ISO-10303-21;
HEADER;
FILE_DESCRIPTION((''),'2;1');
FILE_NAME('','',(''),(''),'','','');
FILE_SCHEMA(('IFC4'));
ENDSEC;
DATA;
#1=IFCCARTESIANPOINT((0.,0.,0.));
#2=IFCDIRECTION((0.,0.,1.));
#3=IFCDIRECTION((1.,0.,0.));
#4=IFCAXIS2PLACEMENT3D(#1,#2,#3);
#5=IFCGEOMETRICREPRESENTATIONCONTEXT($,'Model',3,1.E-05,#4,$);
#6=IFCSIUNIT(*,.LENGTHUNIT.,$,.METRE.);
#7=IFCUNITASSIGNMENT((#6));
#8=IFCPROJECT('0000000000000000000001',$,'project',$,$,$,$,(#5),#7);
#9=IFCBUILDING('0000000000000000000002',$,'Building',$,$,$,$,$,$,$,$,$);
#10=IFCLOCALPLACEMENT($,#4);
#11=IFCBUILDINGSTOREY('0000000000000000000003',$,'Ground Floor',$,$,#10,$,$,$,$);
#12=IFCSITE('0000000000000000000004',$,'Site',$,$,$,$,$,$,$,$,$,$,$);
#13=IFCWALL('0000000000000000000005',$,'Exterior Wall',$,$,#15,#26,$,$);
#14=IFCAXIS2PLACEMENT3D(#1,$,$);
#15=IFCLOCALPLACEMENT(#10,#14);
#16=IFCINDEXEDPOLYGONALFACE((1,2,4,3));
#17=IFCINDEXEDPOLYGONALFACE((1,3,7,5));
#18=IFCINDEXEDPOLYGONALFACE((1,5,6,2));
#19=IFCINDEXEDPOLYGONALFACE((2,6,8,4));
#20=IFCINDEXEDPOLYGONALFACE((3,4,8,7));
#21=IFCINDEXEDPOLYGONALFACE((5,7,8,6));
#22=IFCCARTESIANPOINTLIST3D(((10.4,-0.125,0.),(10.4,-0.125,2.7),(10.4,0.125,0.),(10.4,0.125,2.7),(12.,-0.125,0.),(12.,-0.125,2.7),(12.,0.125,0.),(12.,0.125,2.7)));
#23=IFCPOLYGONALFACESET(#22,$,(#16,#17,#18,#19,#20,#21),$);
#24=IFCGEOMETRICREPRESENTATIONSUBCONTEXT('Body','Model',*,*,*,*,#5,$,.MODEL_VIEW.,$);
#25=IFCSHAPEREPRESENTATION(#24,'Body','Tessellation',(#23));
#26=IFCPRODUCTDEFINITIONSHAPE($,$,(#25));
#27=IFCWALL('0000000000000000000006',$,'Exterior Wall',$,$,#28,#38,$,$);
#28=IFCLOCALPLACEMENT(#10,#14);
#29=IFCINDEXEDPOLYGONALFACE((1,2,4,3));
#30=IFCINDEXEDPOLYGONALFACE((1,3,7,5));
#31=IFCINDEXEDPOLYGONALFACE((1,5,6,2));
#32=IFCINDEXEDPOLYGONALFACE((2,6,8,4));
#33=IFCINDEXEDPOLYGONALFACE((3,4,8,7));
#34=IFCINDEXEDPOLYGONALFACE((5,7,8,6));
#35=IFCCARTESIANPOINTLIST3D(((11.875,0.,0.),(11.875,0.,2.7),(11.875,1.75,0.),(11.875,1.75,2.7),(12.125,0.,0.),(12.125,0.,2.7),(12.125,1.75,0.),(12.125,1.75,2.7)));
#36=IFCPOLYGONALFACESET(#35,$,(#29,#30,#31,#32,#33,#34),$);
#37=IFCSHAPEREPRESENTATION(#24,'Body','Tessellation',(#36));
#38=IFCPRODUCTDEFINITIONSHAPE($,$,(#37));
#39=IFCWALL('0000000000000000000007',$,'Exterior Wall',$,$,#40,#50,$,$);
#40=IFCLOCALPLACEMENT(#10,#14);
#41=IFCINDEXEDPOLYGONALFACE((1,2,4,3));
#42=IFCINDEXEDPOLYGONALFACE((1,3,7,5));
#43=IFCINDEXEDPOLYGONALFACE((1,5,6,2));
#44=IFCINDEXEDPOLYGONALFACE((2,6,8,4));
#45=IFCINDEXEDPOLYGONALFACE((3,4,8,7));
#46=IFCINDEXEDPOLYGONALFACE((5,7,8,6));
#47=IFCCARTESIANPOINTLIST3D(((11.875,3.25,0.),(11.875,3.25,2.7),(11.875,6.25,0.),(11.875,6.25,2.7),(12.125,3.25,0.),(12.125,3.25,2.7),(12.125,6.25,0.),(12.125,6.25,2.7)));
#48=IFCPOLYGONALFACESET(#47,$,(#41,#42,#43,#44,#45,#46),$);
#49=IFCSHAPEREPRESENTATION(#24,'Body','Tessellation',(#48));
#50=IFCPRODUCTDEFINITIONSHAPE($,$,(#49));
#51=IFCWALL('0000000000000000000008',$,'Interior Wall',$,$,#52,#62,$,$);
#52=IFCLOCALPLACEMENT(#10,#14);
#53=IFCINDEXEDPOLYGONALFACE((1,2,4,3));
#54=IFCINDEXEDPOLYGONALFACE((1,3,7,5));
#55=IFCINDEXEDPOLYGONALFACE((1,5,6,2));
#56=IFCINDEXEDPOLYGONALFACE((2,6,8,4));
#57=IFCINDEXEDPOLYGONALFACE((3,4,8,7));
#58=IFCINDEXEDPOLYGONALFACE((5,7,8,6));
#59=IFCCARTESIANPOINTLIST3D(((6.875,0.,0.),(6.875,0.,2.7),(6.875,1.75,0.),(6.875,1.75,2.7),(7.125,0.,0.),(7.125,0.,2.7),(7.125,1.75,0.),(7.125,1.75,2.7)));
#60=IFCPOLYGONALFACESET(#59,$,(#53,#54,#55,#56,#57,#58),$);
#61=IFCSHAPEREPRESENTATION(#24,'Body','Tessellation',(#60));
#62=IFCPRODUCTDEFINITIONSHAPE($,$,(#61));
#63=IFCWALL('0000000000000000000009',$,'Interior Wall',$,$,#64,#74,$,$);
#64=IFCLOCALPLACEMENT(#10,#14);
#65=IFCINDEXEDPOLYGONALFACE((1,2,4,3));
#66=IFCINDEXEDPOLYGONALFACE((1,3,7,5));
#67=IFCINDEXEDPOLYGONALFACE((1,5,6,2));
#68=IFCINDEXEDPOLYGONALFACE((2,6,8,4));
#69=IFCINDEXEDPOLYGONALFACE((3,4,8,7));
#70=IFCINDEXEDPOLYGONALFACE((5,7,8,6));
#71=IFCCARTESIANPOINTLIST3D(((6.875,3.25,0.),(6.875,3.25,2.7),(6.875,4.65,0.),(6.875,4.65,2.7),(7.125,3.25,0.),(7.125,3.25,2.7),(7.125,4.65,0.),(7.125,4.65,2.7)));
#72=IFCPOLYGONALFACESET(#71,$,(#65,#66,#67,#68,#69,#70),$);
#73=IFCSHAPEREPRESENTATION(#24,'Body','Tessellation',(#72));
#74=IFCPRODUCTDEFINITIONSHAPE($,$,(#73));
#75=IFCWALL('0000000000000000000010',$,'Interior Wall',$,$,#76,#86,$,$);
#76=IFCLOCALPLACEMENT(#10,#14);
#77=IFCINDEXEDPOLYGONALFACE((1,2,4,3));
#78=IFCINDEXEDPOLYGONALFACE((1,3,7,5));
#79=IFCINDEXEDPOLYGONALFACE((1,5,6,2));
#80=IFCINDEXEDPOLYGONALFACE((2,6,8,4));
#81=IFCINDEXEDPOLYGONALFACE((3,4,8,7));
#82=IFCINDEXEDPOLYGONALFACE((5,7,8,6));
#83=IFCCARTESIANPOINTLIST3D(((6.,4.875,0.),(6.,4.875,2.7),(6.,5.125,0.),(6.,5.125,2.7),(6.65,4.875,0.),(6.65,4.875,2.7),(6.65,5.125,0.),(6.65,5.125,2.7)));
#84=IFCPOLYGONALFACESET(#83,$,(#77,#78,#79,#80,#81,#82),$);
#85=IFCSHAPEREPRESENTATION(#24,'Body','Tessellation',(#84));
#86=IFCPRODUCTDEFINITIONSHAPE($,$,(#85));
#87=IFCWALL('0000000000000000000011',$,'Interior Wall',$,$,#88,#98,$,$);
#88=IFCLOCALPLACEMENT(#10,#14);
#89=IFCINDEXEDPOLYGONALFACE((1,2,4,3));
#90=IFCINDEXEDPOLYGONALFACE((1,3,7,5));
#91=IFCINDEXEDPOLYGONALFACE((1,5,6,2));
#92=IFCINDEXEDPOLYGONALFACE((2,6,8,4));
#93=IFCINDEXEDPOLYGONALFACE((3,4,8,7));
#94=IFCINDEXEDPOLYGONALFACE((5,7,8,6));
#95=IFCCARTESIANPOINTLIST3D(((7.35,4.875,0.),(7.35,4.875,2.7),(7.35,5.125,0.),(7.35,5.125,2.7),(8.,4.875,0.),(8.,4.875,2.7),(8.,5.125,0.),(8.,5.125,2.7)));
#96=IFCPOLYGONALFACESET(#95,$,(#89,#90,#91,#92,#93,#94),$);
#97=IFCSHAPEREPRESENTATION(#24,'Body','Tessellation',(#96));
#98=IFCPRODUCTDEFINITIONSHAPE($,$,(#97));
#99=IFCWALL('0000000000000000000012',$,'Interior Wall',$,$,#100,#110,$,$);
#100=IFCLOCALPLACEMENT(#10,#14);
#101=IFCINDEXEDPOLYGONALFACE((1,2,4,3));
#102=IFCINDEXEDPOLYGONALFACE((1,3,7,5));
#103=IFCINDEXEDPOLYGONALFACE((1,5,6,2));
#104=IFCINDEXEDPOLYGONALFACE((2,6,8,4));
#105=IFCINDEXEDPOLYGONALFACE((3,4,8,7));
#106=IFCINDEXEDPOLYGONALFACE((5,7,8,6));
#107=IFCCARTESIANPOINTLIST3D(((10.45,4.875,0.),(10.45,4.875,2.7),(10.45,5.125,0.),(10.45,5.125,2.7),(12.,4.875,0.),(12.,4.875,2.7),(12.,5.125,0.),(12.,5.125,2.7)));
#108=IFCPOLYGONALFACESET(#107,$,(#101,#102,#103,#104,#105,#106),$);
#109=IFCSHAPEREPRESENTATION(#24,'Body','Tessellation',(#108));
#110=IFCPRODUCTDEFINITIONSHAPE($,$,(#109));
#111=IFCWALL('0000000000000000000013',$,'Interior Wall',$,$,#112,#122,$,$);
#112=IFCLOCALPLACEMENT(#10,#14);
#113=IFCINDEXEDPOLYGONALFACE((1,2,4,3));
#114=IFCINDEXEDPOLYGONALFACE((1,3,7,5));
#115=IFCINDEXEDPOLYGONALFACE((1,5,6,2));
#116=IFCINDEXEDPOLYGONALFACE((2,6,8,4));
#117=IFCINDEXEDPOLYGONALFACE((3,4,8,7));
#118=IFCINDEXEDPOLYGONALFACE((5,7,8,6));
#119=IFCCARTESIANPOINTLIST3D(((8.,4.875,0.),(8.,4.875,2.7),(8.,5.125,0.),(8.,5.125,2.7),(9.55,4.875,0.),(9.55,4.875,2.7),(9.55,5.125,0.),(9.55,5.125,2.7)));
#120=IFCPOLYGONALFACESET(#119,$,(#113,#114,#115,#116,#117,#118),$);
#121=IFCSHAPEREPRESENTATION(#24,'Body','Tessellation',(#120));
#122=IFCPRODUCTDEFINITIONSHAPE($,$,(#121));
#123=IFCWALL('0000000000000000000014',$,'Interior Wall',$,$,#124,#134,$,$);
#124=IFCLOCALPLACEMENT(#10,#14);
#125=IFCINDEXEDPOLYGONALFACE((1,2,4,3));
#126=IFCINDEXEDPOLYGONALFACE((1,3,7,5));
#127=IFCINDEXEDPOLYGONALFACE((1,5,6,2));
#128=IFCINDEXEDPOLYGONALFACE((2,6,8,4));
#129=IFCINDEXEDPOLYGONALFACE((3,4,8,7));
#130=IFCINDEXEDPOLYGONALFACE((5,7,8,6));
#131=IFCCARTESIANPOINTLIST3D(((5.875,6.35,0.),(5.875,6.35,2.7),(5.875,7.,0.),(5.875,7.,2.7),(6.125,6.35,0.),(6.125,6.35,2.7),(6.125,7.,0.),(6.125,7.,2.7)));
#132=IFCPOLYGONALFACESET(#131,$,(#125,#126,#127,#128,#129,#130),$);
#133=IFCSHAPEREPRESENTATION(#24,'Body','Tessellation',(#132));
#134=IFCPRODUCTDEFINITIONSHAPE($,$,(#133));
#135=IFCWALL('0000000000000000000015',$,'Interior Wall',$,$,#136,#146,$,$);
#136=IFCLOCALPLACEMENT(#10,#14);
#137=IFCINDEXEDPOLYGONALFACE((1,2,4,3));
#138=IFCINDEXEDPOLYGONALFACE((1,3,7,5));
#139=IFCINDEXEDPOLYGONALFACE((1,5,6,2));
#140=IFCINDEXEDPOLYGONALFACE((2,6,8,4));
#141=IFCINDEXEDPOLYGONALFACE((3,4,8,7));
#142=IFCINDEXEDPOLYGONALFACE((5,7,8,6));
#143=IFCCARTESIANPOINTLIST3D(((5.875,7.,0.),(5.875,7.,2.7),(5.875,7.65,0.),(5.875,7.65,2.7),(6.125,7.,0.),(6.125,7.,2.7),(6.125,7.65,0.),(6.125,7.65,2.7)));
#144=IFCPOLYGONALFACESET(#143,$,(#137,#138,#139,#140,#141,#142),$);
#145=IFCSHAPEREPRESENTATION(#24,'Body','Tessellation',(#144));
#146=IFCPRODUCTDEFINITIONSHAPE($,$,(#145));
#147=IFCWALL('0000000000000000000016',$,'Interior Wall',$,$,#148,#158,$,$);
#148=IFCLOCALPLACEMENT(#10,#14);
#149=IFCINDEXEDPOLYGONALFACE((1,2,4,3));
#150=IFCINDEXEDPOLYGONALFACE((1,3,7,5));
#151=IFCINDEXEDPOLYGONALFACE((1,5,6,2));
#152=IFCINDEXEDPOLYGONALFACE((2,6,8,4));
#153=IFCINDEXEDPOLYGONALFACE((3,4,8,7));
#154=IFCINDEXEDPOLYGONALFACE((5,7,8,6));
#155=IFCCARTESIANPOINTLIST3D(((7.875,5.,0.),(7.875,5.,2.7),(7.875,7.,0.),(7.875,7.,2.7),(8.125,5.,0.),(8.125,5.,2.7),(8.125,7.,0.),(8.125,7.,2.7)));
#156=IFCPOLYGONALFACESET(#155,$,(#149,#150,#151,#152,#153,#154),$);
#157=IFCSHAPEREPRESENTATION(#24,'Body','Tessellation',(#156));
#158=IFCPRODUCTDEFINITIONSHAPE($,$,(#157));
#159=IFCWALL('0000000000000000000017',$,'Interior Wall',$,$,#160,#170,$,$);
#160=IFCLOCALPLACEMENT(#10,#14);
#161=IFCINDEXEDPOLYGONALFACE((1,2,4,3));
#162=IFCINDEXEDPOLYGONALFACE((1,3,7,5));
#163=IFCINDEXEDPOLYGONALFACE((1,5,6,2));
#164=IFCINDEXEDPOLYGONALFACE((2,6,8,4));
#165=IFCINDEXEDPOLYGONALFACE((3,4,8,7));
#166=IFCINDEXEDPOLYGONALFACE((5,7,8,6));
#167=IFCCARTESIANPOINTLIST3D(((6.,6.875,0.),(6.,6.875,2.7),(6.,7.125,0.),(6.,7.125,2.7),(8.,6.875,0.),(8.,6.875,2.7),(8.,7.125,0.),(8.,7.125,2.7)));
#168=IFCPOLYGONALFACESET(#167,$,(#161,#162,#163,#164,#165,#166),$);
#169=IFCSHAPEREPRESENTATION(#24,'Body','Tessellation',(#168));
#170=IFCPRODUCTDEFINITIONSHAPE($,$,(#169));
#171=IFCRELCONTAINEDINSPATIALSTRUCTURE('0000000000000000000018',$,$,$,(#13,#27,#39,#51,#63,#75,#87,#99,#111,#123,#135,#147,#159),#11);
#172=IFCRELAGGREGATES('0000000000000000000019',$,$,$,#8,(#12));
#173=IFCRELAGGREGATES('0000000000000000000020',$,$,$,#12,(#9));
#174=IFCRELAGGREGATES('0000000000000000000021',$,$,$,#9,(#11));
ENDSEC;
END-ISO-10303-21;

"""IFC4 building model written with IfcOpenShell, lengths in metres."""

from ifc_helpers import new_model, si_unit, frame, origin_with_axes, place, context, subcontext, project, spatial, indexed_curve, outline, extrude, element, save


model = new_model("IFC4")

# Units and contexts
model_context = context("Model", 3, precision=1e-05, world=origin_with_axes())
body_context = subcontext(model_context, "Body", "Model", "MODEL_VIEW")
ifc_project = project(units=[si_unit("LENGTHUNIT", "METRE")], contexts=[model_context])

# Site, building, storey
site = spatial("IfcSite", under=ifc_project, Name="Site")
building = spatial("IfcBuilding", under=site, Name="Building")
storey_placement = place(None, origin_with_axes())
storey = spatial("IfcBuildingStorey", under=building, at=storey_placement, Name="Ground Floor")

# Walls
wall_1_placement = place(storey_placement, frame((10.4, 0.0, 0.0), z_axis=(0.0, 0.0, 1.0), x_axis=(1.0, 0.0, 0.0)))
element("IfcWall", 1, at=wall_1_placement, inside=storey, Name="Exterior Wall", context=body_context, shape_type="SweptSolid", body=[
    extrude(outline(indexed_curve([(0.0, 0.0), (0.0, 0.25), (1.6, 0.25), (1.6, 0.0), (0.0, 0.0)], self_intersect=False)), frame((0.0, -0.125, 0.0), z_axis=(0.0, 0.0, 1.0), x_axis=(1.0, 0.0, 0.0)), (0.0, 0.0, 1.0), 2.7),
])
wall_2_placement = place(storey_placement, frame((12.0, 0.0, 0.0), z_axis=(0.0, 0.0, 1.0), x_axis=(0.0, 1.0, 0.0)))
element("IfcWall", 2, at=wall_2_placement, inside=storey, Name="Exterior Wall", context=body_context, shape_type="SweptSolid", body=[
    extrude(outline(indexed_curve([(0.0, 0.0), (0.0, 0.25), (1.75, 0.25), (1.75, 0.0), (0.0, 0.0)], self_intersect=False)), frame((0.0, -0.125, 0.0), z_axis=(0.0, 0.0, 1.0), x_axis=(1.0, 0.0, 0.0)), (0.0, 0.0, 1.0), 2.7),
])
wall_3_placement = place(storey_placement, frame((12.0, 3.25, 0.0), z_axis=(0.0, 0.0, 1.0), x_axis=(0.0, 1.0, 0.0)))
element("IfcWall", 3, at=wall_3_placement, inside=storey, Name="Exterior Wall", context=body_context, shape_type="SweptSolid", body=[
    extrude(outline(indexed_curve([(0.0, 0.0), (0.0, 0.25), (3.0, 0.25), (3.0, 0.0), (0.0, 0.0)], self_intersect=False)), frame((0.0, -0.125, 0.0), z_axis=(0.0, 0.0, 1.0), x_axis=(1.0, 0.0, 0.0)), (0.0, 0.0, 1.0), 2.7),
])
wall_4_placement = place(storey_placement, frame((7.0, 0.0, 0.0), z_axis=(0.0, 0.0, 1.0), x_axis=(0.0, 1.0, 0.0)))
element("IfcWall", 4, at=wall_4_placement, inside=storey, Name="Interior Wall", context=body_context, shape_type="SweptSolid", body=[
    extrude(outline(indexed_curve([(0.0, 0.0), (0.0, 0.25), (1.75, 0.25), (1.75, 0.0), (0.0, 0.0)], self_intersect=False)), frame((0.0, -0.125, 0.0), z_axis=(0.0, 0.0, 1.0), x_axis=(1.0, 0.0, 0.0)), (0.0, 0.0, 1.0), 2.7),
])
wall_5_placement = place(storey_placement, frame((7.0, 3.25, 0.0), z_axis=(0.0, 0.0, 1.0), x_axis=(0.0, 1.0, 0.0)))
element("IfcWall", 5, at=wall_5_placement, inside=storey, Name="Interior Wall", context=body_context, shape_type="SweptSolid", body=[
    extrude(outline(indexed_curve([(0.0, 0.0), (0.0, 0.25), (1.4, 0.25), (1.4, 0.0), (0.0, 0.0)], self_intersect=False)), frame((0.0, -0.125, 0.0), z_axis=(0.0, 0.0, 1.0), x_axis=(1.0, 0.0, 0.0)), (0.0, 0.0, 1.0), 2.7),
])
for number, where, z_axis, x_axis, name in (
    (6, (6.65, 5.0, 0.0), (0.0, 0.0, 1.0), (-1.0, 0.0, 0.0), "Interior Wall"),
    (7, (8.0, 5.0, 0.0), (0.0, 0.0, 1.0), (-1.0, 0.0, 0.0), "Interior Wall"),
):
    element("IfcWall", number, at=place(storey_placement, frame(where, z_axis=z_axis, x_axis=x_axis)), inside=storey, Name=name, context=body_context, shape_type="SweptSolid", body=[
        extrude(outline(indexed_curve([(0.0, 0.0), (0.0, 0.25), (0.65, 0.25), (0.65, 0.0), (0.0, 0.0)], self_intersect=False)), frame((0.0, -0.125, 0.0), z_axis=(0.0, 0.0, 1.0), x_axis=(1.0, 0.0, 0.0)), (0.0, 0.0, 1.0), 2.7),
    ])
for number, where, z_axis, x_axis, name in (
    (8, (12.0, 5.0, 0.0), (0.0, 0.0, 1.0), (-1.0, 0.0, 0.0), "Interior Wall"),
    (9, (9.55, 5.0, 0.0), (0.0, 0.0, 1.0), (-1.0, 0.0, 0.0), "Interior Wall"),
):
    element("IfcWall", number, at=place(storey_placement, frame(where, z_axis=z_axis, x_axis=x_axis)), inside=storey, Name=name, context=body_context, shape_type="SweptSolid", body=[
        extrude(outline(indexed_curve([(0.0, 0.0), (0.0, 0.25), (1.55, 0.25), (1.55, 0.0), (0.0, 0.0)], self_intersect=False)), frame((0.0, -0.125, 0.0), z_axis=(0.0, 0.0, 1.0), x_axis=(1.0, 0.0, 0.0)), (0.0, 0.0, 1.0), 2.7),
    ])
for number, where, z_axis, x_axis, name in (
    (10, (6.0, 6.35, 0.0), (0.0, 0.0, 1.0), (0.0, 1.0, 0.0), "Interior Wall"),
    (11, (6.0, 7.0, 0.0), (0.0, 0.0, 1.0), (0.0, 1.0, 0.0), "Interior Wall"),
):
    element("IfcWall", number, at=place(storey_placement, frame(where, z_axis=z_axis, x_axis=x_axis)), inside=storey, Name=name, context=body_context, shape_type="SweptSolid", body=[
        extrude(outline(indexed_curve([(0.0, 0.0), (0.0, 0.25), (0.65, 0.25), (0.65, 0.0), (0.0, 0.0)], self_intersect=False)), frame((0.0, -0.125, 0.0), z_axis=(0.0, 0.0, 1.0), x_axis=(1.0, 0.0, 0.0)), (0.0, 0.0, 1.0), 2.7),
    ])
for number, where, z_axis, x_axis, name in (
    (12, (8.0, 5.0, 0.0), (0.0, 0.0, 1.0), (0.0, 1.0, 0.0), "Interior Wall"),
    (13, (8.0, 7.0, 0.0), (0.0, 0.0, 1.0), (-1.0, 0.0, 0.0), "Interior Wall"),
):
    element("IfcWall", number, at=place(storey_placement, frame(where, z_axis=z_axis, x_axis=x_axis)), inside=storey, Name=name, context=body_context, shape_type="SweptSolid", body=[
        extrude(outline(indexed_curve([(0.0, 0.0), (0.0, 0.25), (2.0, 0.25), (2.0, 0.0), (0.0, 0.0)], self_intersect=False)), frame((0.0, -0.125, 0.0), z_axis=(0.0, 0.0, 1.0), x_axis=(1.0, 0.0, 0.0)), (0.0, 0.0, 1.0), 2.7),
    ])

save(model, "model.ifc")
